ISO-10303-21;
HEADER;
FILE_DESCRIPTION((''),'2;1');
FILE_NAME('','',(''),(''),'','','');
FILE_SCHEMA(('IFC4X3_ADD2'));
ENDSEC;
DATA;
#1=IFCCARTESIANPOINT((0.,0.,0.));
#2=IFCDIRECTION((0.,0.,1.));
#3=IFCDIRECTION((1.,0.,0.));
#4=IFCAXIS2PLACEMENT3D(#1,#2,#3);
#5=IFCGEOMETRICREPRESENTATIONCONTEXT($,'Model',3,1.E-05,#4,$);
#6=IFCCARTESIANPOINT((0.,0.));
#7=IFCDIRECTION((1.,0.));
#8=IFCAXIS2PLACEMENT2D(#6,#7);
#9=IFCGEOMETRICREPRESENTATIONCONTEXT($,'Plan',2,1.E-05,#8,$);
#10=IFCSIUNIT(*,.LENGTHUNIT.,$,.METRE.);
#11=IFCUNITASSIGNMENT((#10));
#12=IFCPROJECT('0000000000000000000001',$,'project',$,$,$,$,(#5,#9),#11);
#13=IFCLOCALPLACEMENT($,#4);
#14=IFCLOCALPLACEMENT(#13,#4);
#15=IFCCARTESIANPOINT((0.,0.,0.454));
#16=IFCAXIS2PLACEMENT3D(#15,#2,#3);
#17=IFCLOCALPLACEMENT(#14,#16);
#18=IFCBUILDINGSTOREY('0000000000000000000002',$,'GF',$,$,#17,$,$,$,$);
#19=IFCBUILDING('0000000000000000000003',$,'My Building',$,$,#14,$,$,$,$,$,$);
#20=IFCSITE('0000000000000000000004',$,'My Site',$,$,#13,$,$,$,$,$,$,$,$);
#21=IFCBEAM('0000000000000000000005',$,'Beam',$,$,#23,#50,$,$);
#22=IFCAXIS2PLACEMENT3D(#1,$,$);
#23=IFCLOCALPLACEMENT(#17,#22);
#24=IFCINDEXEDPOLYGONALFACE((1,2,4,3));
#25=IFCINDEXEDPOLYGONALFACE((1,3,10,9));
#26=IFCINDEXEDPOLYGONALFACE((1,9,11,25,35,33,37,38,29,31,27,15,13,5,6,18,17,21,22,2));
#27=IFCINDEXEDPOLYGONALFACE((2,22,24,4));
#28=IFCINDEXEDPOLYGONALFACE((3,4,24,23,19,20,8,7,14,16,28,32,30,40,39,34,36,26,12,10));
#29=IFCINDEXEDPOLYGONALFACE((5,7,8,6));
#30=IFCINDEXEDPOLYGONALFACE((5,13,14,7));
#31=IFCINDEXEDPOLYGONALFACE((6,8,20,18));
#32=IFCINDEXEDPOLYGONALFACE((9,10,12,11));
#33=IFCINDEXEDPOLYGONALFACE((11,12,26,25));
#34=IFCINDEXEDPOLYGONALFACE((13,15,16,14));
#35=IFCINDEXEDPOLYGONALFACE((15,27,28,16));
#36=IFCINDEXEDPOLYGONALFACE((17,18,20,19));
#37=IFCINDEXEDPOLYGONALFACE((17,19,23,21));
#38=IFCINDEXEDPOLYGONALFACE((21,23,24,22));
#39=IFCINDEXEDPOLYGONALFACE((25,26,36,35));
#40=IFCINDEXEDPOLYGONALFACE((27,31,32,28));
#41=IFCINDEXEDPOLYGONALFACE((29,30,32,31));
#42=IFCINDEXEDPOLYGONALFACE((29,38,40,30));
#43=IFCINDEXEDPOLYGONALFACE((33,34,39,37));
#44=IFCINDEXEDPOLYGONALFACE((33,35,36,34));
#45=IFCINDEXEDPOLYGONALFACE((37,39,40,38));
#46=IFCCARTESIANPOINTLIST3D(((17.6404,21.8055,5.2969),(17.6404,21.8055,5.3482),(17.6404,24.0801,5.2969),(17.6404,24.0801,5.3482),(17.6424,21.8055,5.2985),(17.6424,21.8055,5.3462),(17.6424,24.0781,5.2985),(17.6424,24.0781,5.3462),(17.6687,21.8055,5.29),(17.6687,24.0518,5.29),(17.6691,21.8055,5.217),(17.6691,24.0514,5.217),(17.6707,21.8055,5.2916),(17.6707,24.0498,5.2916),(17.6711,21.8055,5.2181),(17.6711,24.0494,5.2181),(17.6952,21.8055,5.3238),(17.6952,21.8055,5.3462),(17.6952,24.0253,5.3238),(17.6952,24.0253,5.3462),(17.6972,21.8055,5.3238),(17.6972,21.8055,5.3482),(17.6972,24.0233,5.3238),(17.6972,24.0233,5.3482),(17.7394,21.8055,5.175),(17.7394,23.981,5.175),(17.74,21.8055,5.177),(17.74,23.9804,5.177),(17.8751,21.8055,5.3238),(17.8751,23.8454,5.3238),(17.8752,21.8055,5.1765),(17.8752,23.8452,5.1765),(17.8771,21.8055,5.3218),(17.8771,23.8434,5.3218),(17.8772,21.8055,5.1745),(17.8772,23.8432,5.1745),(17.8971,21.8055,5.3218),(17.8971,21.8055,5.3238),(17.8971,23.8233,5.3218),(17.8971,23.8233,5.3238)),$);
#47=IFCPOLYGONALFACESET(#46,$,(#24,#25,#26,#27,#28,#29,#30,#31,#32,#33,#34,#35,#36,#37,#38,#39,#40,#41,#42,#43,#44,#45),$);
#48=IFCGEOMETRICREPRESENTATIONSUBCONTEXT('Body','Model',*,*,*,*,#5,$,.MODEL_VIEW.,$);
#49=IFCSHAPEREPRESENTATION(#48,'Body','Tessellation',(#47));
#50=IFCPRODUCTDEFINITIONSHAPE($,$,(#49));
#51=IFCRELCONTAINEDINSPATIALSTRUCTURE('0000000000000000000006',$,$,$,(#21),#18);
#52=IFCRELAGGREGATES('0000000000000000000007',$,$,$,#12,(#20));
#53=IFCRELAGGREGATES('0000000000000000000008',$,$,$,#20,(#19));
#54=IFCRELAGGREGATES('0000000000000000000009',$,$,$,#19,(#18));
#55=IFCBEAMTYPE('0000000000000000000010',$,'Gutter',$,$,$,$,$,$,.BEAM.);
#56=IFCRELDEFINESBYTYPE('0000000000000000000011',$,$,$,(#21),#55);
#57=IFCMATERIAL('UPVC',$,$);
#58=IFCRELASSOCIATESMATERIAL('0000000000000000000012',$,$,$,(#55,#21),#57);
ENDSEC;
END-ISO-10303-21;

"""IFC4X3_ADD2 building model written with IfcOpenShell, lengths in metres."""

from ifc_helpers import new_model, si_unit, frame, origin_with_axes, origin_2d_with_axis, place, context, subcontext, project, spatial, indexed_curve, outline, extrude, clip, halfspace, material, material_profile, profile_set, profile_usage, type_object, element, save


model = new_model("IFC4X3_ADD2")

# Units and contexts
model_context = context("Model", 3, precision=1e-05, world=origin_with_axes())
plan_context = context("Plan", 2, precision=1e-05, world=origin_2d_with_axis())
body_context = subcontext(model_context, "Body", "Model", "MODEL_VIEW")
ifc_project = project(units=[si_unit("LENGTHUNIT", "METRE")], contexts=[model_context, plan_context])

# Site, building, storey
site_placement = place(None, origin_with_axes())
site = spatial("IfcSite", under=ifc_project, at=site_placement, Name="My Site")
building_placement = place(site_placement, origin_with_axes())
building = spatial("IfcBuilding", under=site, at=building_placement, Name="My Building")
storey_placement = place(building_placement, frame((0.0, 0.0, 0.454), z_axis=(0.0, 0.0, 1.0), x_axis=(1.0, 0.0, 0.0)))
storey = spatial("IfcBuildingStorey", under=building, at=storey_placement, Name="GF")

# Shared definitions
ifc_material_1 = material(Name="UPVC")

# Beam
ifc_material_profile_1 = material_profile(ifc_material_1, outline(indexed_curve([(0.0548, 0.1717), (0.002, 0.1717), (0.002, 0.124), (0.0303, 0.1171), (0.0307, 0.0436), (0.0996, 0.0025), (0.2349, 0.002), (0.2347, 0.1494), (0.2567, 0.1494), (0.2567, 0.1474), (0.2367, 0.1474), (0.2369, 0.0), (0.0991, 0.0005), (0.0287, 0.0425), (0.0283, 0.1155), (0.0, 0.1224), (0.0, 0.1737), (0.0568, 0.1737), (0.0568, 0.1494), (0.0548, 0.1494), (0.0548, 0.1717)])))
ifc_profile_set_1 = profile_set([ifc_material_profile_1])
beam_type_1 = type_object("IfcBeamType", Name="Gutter", PredefinedType="BEAM", material=ifc_profile_set_1)
ifc_profile_usage_1 = profile_usage(ifc_profile_set_1)
beam_1_placement = place(storey_placement, frame((17.6404, 24.0801, 5.1745), z_axis=(0.0, -1.0, 0.0), x_axis=(1.0, 0.0, 0.0)))
element("IfcBeam", 1, at=beam_1_placement, inside=storey, type_object=beam_type_1, material=ifc_profile_usage_1, Name="Beam", context=body_context, shape_type="Clipping", body=[
    clip(extrude(outline(indexed_curve([(0.0548, 0.1717), (0.002, 0.1717), (0.002, 0.124), (0.0303, 0.1171), (0.0307, 0.0436), (0.0996, 0.0025), (0.2349, 0.002), (0.2347, 0.1494), (0.2567, 0.1494), (0.2567, 0.1474), (0.2367, 0.1474), (0.2369, 0.0), (0.0991, 0.0005), (0.0287, 0.0425), (0.0283, 0.1155), (0.0, 0.1224), (0.0, 0.1737), (0.0568, 0.1737), (0.0568, 0.1494), (0.0548, 0.1494), (0.0548, 0.1717)])), origin_with_axes(), (0.0, 0.0, 1.0), 2.2745), halfspace(frame((0.0, -5.6285, 0.0), z_axis=(0.707106, 0.0, -0.707107), x_axis=(0.0, -1.0, 0.0)), False)),
])

save(model, "model.ifc")
